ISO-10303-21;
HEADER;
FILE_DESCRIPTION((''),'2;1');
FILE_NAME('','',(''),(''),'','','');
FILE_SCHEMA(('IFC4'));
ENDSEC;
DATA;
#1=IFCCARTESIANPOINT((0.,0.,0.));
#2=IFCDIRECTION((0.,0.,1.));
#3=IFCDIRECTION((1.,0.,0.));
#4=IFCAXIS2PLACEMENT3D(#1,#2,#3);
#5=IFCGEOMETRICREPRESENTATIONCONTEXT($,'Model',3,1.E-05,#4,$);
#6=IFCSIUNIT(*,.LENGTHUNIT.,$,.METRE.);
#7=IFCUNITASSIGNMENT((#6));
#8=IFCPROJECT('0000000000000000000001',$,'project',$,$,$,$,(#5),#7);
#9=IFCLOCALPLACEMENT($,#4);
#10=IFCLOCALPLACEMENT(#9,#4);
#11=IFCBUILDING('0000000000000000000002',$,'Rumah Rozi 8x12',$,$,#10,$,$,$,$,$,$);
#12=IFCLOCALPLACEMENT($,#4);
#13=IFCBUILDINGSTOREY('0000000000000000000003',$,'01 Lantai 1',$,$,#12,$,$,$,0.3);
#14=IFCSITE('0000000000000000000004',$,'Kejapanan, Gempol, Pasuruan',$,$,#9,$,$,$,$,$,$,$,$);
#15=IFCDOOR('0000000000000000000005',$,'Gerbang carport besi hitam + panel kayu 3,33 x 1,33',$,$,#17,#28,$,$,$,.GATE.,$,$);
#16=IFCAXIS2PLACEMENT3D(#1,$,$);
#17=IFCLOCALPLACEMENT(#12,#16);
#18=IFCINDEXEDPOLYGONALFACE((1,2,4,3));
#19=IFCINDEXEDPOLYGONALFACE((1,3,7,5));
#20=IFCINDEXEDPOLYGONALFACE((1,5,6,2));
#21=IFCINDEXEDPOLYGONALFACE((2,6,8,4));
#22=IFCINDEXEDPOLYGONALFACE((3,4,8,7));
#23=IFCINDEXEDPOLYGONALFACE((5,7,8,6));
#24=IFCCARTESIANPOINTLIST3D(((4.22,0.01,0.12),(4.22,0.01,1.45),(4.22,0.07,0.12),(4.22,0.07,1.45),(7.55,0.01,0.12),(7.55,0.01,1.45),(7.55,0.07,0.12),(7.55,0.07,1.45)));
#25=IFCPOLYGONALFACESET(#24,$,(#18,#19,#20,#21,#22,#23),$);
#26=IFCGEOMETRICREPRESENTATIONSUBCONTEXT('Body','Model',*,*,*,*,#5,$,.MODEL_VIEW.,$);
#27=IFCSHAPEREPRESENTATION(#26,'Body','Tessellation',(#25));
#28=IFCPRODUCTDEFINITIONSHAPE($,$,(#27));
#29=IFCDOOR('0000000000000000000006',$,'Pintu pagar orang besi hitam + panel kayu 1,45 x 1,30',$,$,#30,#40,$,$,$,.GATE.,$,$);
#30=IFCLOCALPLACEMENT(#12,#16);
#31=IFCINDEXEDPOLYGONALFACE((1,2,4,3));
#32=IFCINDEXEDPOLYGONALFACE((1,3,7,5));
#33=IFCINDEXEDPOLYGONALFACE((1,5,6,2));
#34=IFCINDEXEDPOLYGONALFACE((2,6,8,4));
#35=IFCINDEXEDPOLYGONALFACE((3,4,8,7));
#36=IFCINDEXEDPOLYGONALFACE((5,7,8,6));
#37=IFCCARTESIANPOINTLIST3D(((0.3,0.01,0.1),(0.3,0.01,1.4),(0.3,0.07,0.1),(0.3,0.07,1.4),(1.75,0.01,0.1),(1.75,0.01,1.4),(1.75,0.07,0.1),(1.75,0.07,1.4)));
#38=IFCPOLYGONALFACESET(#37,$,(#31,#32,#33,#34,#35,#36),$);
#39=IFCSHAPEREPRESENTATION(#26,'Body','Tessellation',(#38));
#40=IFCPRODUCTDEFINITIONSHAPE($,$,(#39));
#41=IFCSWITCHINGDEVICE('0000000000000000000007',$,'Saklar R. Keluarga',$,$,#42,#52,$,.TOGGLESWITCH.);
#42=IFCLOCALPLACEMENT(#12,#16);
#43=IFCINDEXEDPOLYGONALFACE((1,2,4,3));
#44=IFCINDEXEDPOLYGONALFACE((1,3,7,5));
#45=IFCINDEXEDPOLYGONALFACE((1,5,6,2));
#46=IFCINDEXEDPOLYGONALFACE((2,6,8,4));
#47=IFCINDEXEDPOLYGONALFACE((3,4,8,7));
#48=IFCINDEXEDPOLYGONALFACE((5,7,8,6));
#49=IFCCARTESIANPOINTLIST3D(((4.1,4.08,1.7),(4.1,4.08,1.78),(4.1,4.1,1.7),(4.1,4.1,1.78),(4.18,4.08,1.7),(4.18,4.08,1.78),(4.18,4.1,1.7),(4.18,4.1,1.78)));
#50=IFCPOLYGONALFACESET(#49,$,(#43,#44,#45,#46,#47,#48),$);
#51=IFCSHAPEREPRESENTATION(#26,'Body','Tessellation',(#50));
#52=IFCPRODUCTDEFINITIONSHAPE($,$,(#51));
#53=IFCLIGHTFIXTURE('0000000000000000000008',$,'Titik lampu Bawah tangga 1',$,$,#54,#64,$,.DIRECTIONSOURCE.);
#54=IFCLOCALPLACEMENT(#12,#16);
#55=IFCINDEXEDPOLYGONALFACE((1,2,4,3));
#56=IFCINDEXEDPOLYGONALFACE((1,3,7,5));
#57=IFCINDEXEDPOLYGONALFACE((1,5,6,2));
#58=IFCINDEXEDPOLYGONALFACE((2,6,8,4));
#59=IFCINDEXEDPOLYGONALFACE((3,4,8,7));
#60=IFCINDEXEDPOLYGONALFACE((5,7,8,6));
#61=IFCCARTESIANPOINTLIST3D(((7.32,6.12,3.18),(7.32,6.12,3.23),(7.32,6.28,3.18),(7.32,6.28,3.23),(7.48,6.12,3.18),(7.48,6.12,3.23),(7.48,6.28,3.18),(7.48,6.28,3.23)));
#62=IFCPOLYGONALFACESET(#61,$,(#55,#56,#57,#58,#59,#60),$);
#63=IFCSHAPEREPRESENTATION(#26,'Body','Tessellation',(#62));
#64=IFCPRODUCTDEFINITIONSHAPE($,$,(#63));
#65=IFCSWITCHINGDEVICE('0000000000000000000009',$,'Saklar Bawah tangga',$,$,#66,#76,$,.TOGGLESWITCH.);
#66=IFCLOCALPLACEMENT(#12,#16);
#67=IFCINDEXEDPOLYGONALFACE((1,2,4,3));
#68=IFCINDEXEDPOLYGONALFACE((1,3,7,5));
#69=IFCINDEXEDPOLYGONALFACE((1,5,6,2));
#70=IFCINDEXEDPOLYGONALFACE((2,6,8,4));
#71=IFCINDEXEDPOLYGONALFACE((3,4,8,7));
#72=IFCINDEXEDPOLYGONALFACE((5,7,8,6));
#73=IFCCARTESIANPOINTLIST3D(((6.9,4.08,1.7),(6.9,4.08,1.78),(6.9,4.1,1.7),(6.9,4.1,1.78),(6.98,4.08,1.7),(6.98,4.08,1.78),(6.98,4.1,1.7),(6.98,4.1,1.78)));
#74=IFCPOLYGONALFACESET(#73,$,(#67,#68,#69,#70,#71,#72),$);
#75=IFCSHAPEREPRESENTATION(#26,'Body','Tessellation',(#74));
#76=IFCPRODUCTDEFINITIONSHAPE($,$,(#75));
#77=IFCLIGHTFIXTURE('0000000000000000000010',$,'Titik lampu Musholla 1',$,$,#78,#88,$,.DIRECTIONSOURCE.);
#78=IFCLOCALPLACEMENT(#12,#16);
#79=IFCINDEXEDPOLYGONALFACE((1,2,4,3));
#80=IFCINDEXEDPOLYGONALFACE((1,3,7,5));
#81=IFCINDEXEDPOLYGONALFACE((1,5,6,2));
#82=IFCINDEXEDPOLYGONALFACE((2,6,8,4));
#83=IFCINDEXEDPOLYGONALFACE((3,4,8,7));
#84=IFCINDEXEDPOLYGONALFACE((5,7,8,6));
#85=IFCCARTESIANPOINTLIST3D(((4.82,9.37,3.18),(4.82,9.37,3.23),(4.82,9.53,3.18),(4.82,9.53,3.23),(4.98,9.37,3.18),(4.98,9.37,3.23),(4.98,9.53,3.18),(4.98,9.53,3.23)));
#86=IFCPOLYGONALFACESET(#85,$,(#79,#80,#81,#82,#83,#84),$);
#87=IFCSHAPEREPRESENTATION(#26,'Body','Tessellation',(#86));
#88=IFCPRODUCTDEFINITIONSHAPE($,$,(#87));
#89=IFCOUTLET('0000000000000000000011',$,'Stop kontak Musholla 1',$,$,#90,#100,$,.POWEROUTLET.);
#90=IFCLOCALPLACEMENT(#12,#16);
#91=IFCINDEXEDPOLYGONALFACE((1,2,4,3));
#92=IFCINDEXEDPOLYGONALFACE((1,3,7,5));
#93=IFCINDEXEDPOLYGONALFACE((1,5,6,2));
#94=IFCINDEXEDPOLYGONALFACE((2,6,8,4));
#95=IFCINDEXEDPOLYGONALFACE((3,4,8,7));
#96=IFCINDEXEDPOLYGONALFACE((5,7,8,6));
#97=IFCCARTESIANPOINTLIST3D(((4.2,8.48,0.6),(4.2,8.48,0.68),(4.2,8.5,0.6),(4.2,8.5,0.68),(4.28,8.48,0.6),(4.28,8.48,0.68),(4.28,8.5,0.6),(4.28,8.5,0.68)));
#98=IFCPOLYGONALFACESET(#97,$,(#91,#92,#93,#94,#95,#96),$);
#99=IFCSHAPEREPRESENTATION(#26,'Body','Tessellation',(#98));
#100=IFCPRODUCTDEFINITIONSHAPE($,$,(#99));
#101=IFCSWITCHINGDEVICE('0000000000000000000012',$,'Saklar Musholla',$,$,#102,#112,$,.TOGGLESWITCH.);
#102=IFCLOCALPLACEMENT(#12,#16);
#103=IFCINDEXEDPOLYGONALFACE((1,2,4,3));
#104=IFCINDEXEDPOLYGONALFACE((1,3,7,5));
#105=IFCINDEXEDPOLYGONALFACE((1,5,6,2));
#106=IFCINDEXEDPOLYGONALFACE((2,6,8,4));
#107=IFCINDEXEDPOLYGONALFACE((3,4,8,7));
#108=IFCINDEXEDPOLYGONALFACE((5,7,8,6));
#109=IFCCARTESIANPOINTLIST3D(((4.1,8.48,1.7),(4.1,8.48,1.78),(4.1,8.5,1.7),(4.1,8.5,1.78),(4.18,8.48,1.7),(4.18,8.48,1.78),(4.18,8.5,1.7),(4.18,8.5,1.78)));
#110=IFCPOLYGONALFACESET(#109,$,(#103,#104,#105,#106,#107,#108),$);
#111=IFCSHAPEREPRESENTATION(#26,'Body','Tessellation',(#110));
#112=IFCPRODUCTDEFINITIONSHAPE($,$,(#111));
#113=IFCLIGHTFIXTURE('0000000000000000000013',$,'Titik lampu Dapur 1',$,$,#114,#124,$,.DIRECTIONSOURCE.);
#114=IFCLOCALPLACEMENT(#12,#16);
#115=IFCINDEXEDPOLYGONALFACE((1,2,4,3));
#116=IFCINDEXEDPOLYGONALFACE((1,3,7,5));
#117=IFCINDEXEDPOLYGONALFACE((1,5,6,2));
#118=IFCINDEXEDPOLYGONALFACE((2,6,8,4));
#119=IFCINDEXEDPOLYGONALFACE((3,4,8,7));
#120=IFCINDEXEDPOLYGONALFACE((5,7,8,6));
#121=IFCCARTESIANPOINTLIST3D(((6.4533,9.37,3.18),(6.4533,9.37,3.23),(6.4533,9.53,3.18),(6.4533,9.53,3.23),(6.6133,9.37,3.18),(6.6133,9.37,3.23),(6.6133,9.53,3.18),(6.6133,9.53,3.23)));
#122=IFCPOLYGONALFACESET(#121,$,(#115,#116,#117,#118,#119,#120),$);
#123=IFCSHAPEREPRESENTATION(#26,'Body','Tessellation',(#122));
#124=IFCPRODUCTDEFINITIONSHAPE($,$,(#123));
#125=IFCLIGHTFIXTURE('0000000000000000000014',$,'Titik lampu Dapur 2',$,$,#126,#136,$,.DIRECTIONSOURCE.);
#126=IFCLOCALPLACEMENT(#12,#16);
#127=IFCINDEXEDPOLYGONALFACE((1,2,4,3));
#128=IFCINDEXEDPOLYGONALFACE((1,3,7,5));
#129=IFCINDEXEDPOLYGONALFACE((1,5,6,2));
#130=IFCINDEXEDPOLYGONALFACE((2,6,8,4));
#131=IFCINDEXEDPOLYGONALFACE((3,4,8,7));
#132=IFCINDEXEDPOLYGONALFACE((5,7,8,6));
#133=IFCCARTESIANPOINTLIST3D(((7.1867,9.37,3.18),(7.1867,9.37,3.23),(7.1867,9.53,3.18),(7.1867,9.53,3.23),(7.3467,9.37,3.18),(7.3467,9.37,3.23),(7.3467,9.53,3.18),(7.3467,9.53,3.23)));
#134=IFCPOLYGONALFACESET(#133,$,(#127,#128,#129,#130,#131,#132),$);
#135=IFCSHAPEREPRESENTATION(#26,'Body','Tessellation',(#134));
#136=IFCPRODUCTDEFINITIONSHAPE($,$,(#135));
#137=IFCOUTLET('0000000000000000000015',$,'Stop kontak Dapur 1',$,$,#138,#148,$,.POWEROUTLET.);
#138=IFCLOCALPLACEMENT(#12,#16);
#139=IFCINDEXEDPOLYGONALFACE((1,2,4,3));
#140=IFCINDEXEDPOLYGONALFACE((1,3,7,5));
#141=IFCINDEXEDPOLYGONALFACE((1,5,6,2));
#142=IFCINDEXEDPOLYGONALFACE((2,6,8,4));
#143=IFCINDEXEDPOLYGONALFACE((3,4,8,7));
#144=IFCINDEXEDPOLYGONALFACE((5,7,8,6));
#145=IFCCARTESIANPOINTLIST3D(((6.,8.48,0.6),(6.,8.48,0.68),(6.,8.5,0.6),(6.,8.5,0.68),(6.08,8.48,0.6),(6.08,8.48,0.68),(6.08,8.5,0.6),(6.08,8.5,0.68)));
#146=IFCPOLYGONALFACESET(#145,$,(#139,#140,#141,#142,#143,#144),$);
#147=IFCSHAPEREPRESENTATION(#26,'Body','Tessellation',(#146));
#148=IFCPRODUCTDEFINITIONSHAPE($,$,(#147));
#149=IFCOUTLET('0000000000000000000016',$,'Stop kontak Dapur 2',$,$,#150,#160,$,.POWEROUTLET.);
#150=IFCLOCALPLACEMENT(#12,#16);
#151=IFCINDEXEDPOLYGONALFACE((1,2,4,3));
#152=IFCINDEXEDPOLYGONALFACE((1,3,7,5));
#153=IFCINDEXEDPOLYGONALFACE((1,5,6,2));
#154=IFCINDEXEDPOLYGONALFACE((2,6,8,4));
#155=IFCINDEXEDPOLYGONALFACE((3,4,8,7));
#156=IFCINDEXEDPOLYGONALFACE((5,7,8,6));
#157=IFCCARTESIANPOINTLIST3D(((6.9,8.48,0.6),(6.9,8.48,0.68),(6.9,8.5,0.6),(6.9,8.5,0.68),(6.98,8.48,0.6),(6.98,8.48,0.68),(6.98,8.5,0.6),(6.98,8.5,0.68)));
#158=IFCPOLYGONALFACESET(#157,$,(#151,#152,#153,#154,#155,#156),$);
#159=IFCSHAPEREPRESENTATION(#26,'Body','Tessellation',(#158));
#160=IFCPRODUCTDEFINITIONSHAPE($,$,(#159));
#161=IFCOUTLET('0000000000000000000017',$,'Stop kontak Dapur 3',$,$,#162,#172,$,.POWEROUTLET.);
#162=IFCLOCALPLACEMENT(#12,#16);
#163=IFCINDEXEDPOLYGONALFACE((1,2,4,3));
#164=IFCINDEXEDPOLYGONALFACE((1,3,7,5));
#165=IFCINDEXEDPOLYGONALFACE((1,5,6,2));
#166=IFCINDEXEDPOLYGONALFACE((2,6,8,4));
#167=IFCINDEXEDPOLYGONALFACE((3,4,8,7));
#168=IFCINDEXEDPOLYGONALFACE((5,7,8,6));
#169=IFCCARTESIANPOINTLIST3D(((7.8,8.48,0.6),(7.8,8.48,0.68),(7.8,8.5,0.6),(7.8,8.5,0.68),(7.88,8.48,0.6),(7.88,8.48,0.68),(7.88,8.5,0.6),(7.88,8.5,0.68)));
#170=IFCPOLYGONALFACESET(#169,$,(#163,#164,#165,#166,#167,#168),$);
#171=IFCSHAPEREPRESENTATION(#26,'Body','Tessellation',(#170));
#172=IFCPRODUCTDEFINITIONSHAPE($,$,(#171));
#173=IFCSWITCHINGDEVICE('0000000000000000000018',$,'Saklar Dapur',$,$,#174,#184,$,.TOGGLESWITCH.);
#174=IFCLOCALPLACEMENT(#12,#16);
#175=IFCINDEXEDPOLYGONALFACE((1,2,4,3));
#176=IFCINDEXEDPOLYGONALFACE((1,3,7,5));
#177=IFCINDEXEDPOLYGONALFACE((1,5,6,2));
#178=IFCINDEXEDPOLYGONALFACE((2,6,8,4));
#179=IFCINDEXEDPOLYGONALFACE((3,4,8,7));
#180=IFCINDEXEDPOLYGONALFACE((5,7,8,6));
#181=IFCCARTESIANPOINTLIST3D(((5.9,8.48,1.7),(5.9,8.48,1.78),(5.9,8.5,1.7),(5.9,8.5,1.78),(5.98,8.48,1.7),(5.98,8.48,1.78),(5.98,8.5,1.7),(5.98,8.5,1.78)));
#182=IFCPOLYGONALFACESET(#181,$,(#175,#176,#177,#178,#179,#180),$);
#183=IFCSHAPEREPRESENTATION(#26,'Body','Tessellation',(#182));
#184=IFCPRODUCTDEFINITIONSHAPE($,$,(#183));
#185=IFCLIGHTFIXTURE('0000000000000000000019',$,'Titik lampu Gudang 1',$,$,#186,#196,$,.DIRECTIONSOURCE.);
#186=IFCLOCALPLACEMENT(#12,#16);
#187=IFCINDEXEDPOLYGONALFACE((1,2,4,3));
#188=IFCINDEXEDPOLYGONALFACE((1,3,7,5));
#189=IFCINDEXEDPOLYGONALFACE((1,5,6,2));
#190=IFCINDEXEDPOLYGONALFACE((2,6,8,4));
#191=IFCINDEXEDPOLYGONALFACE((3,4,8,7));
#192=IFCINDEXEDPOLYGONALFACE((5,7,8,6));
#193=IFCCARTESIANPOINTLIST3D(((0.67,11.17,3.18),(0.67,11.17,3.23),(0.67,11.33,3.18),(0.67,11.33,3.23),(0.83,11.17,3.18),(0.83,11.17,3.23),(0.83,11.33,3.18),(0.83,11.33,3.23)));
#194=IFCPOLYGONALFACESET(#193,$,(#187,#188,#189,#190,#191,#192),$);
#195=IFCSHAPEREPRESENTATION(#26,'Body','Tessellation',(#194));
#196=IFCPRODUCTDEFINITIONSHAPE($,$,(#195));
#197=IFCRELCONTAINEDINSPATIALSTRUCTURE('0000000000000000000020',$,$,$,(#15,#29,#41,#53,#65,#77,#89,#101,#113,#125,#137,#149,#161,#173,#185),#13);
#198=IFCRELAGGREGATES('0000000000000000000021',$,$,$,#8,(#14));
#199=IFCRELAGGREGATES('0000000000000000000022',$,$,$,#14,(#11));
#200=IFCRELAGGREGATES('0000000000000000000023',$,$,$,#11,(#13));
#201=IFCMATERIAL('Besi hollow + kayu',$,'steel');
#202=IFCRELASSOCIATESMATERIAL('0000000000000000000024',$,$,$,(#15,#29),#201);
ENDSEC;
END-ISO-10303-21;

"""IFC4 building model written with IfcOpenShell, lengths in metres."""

from ifc_helpers import new_model, si_unit, frame, origin_with_axes, place, context, subcontext, project, spatial, line, indexed_curve, outline, extrude, material, element, save


model = new_model("IFC4")

# Units and contexts
model_context = context("Model", 3, precision=1e-05, world=origin_with_axes())
body_context = subcontext(model_context, "Body", "Model", "MODEL_VIEW")
ifc_project = project(units=[si_unit("LENGTHUNIT", "METRE")], contexts=[model_context])

# Site, building, storey
site_placement = place(None, origin_with_axes())
site = spatial("IfcSite", under=ifc_project, at=site_placement, Name="Kejapanan, Gempol, Pasuruan")
building_placement = place(site_placement, origin_with_axes())
building = spatial("IfcBuilding", under=site, at=building_placement, Name="Rumah Rozi 8x12")
storey_placement = place(None, origin_with_axes())
storey = spatial("IfcBuildingStorey", under=building, at=storey_placement, Name="01 Lantai 1", Elevation=0.3)

# Doors
ifc_material = material(Name="Besi hollow + kayu", Category="steel")
door_1_placement = place(storey_placement, origin_with_axes())
element("IfcDoor", 1, at=door_1_placement, inside=storey, material=ifc_material, Name="Gerbang carport besi hitam + panel kayu 3,33 x 1,33", PredefinedType="GATE", context=body_context, shape_type="SweptSolid", body=[
    extrude(outline(indexed_curve([(4.22, 0.01), (7.55, 0.01), (7.55, 0.07), (4.22, 0.07)], segments=[line(1, 2, 3, 4, 1)])), frame((0.0, 0.0, 0.12), z_axis=(0.0, 0.0, 1.0), x_axis=(1.0, 0.0, 0.0)), (0.0, 0.0, 1.0), 1.33),
])
door_2_placement = place(storey_placement, origin_with_axes())
element("IfcDoor", 2, at=door_2_placement, inside=storey, material=ifc_material, Name="Pintu pagar orang besi hitam + panel kayu 1,45 x 1,30", PredefinedType="GATE", context=body_context, shape_type="SweptSolid", body=[
    extrude(outline(indexed_curve([(0.3, 0.01), (1.75, 0.01), (1.75, 0.07), (0.3, 0.07)], segments=[line(1, 2, 3, 4, 1)])), frame((0.0, 0.0, 0.1), z_axis=(0.0, 0.0, 1.0), x_axis=(1.0, 0.0, 0.0)), (0.0, 0.0, 1.0), 1.3),
])

# Switching device
switching_device_1_placement = place(storey_placement, origin_with_axes())
element("IfcSwitchingDevice", 3, at=switching_device_1_placement, inside=storey, Name="Saklar R. Keluarga", PredefinedType="TOGGLESWITCH", context=body_context, shape_type="SweptSolid", body=[
    extrude(outline(indexed_curve([(4.1, 4.08), (4.18, 4.08), (4.18, 4.1), (4.1, 4.1)], segments=[line(1, 2, 3, 4, 1)])), frame((0.0, 0.0, 1.7), z_axis=(0.0, 0.0, 1.0), x_axis=(1.0, 0.0, 0.0)), (0.0, 0.0, 1.0), 0.08),
])

# Light fixture
light_fixture_1_placement = place(storey_placement, origin_with_axes())
element("IfcLightFixture", 4, at=light_fixture_1_placement, inside=storey, Name="Titik lampu Bawah tangga 1", PredefinedType="DIRECTIONSOURCE", context=body_context, shape_type="SweptSolid", body=[
    extrude(outline(indexed_curve([(7.32, 6.12), (7.48, 6.12), (7.48, 6.28), (7.32, 6.28)], segments=[line(1, 2, 3, 4, 1)])), frame((0.0, 0.0, 3.18), z_axis=(0.0, 0.0, 1.0), x_axis=(1.0, 0.0, 0.0)), (0.0, 0.0, 1.0), 0.05),
])

# Switching device
switching_device_2_placement = place(storey_placement, origin_with_axes())
element("IfcSwitchingDevice", 5, at=switching_device_2_placement, inside=storey, Name="Saklar Bawah tangga", PredefinedType="TOGGLESWITCH", context=body_context, shape_type="SweptSolid", body=[
    extrude(outline(indexed_curve([(6.9, 4.08), (6.98, 4.08), (6.98, 4.1), (6.9, 4.1)], segments=[line(1, 2, 3, 4, 1)])), frame((0.0, 0.0, 1.7), z_axis=(0.0, 0.0, 1.0), x_axis=(1.0, 0.0, 0.0)), (0.0, 0.0, 1.0), 0.08),
])

# Light fixture
light_fixture_2_placement = place(storey_placement, origin_with_axes())
element("IfcLightFixture", 6, at=light_fixture_2_placement, inside=storey, Name="Titik lampu Musholla 1", PredefinedType="DIRECTIONSOURCE", context=body_context, shape_type="SweptSolid", body=[
    extrude(outline(indexed_curve([(4.82, 9.37), (4.98, 9.37), (4.98, 9.53), (4.82, 9.53)], segments=[line(1, 2, 3, 4, 1)])), frame((0.0, 0.0, 3.18), z_axis=(0.0, 0.0, 1.0), x_axis=(1.0, 0.0, 0.0)), (0.0, 0.0, 1.0), 0.05),
])

# Outlet
outlet_1_placement = place(storey_placement, origin_with_axes())
element("IfcOutlet", 7, at=outlet_1_placement, inside=storey, Name="Stop kontak Musholla 1", PredefinedType="POWEROUTLET", context=body_context, shape_type="SweptSolid", body=[
    extrude(outline(indexed_curve([(4.2, 8.48), (4.28, 8.48), (4.28, 8.5), (4.2, 8.5)], segments=[line(1, 2, 3, 4, 1)])), frame((0.0, 0.0, 0.6), z_axis=(0.0, 0.0, 1.0), x_axis=(1.0, 0.0, 0.0)), (0.0, 0.0, 1.0), 0.08),
])

# Switching device
switching_device_3_placement = place(storey_placement, origin_with_axes())
element("IfcSwitchingDevice", 8, at=switching_device_3_placement, inside=storey, Name="Saklar Musholla", PredefinedType="TOGGLESWITCH", context=body_context, shape_type="SweptSolid", body=[
    extrude(outline(indexed_curve([(4.1, 8.48), (4.18, 8.48), (4.18, 8.5), (4.1, 8.5)], segments=[line(1, 2, 3, 4, 1)])), frame((0.0, 0.0, 1.7), z_axis=(0.0, 0.0, 1.0), x_axis=(1.0, 0.0, 0.0)), (0.0, 0.0, 1.0), 0.08),
])

# Light fixtures
light_fixture_3_placement = place(storey_placement, origin_with_axes())
element("IfcLightFixture", 9, at=light_fixture_3_placement, inside=storey, Name="Titik lampu Dapur 1", PredefinedType="DIRECTIONSOURCE", context=body_context, shape_type="SweptSolid", body=[
    extrude(outline(indexed_curve([(6.4533, 9.37), (6.6133, 9.37), (6.6133, 9.53), (6.4533, 9.53)], segments=[line(1, 2, 3, 4, 1)])), frame((0.0, 0.0, 3.18), z_axis=(0.0, 0.0, 1.0), x_axis=(1.0, 0.0, 0.0)), (0.0, 0.0, 1.0), 0.05),
])
light_fixture_4_placement = place(storey_placement, origin_with_axes())
element("IfcLightFixture", 10, at=light_fixture_4_placement, inside=storey, Name="Titik lampu Dapur 2", PredefinedType="DIRECTIONSOURCE", context=body_context, shape_type="SweptSolid", body=[
    extrude(outline(indexed_curve([(7.1867, 9.37), (7.3467, 9.37), (7.3467, 9.53), (7.1867, 9.53)], segments=[line(1, 2, 3, 4, 1)])), frame((0.0, 0.0, 3.18), z_axis=(0.0, 0.0, 1.0), x_axis=(1.0, 0.0, 0.0)), (0.0, 0.0, 1.0), 0.05),
])

# Outlets
outlet_2_placement = place(storey_placement, origin_with_axes())
element("IfcOutlet", 11, at=outlet_2_placement, inside=storey, Name="Stop kontak Dapur 1", PredefinedType="POWEROUTLET", context=body_context, shape_type="SweptSolid", body=[
    extrude(outline(indexed_curve([(6.0, 8.48), (6.08, 8.48), (6.08, 8.5), (6.0, 8.5)], segments=[line(1, 2, 3, 4, 1)])), frame((0.0, 0.0, 0.6), z_axis=(0.0, 0.0, 1.0), x_axis=(1.0, 0.0, 0.0)), (0.0, 0.0, 1.0), 0.08),
])
outlet_3_placement = place(storey_placement, origin_with_axes())
element("IfcOutlet", 12, at=outlet_3_placement, inside=storey, Name="Stop kontak Dapur 2", PredefinedType="POWEROUTLET", context=body_context, shape_type="SweptSolid", body=[
    extrude(outline(indexed_curve([(6.9, 8.48), (6.98, 8.48), (6.98, 8.5), (6.9, 8.5)], segments=[line(1, 2, 3, 4, 1)])), frame((0.0, 0.0, 0.6), z_axis=(0.0, 0.0, 1.0), x_axis=(1.0, 0.0, 0.0)), (0.0, 0.0, 1.0), 0.08),
])
outlet_4_placement = place(storey_placement, origin_with_axes())
element("IfcOutlet", 13, at=outlet_4_placement, inside=storey, Name="Stop kontak Dapur 3", PredefinedType="POWEROUTLET", context=body_context, shape_type="SweptSolid", body=[
    extrude(outline(indexed_curve([(7.8, 8.48), (7.88, 8.48), (7.88, 8.5), (7.8, 8.5)], segments=[line(1, 2, 3, 4, 1)])), frame((0.0, 0.0, 0.6), z_axis=(0.0, 0.0, 1.0), x_axis=(1.0, 0.0, 0.0)), (0.0, 0.0, 1.0), 0.08),
])

# Switching device
switching_device_4_placement = place(storey_placement, origin_with_axes())
element("IfcSwitchingDevice", 14, at=switching_device_4_placement, inside=storey, Name="Saklar Dapur", PredefinedType="TOGGLESWITCH", context=body_context, shape_type="SweptSolid", body=[
    extrude(outline(indexed_curve([(5.9, 8.48), (5.98, 8.48), (5.98, 8.5), (5.9, 8.5)], segments=[line(1, 2, 3, 4, 1)])), frame((0.0, 0.0, 1.7), z_axis=(0.0, 0.0, 1.0), x_axis=(1.0, 0.0, 0.0)), (0.0, 0.0, 1.0), 0.08),
])

# Light fixture
light_fixture_5_placement = place(storey_placement, origin_with_axes())
element("IfcLightFixture", 15, at=light_fixture_5_placement, inside=storey, Name="Titik lampu Gudang 1", PredefinedType="DIRECTIONSOURCE", context=body_context, shape_type="SweptSolid", body=[
    extrude(outline(indexed_curve([(0.67, 11.17), (0.83, 11.17), (0.83, 11.33), (0.67, 11.33)], segments=[line(1, 2, 3, 4, 1)])), frame((0.0, 0.0, 3.18), z_axis=(0.0, 0.0, 1.0), x_axis=(1.0, 0.0, 0.0)), (0.0, 0.0, 1.0), 0.05),
])

save(model, "model.ifc")
